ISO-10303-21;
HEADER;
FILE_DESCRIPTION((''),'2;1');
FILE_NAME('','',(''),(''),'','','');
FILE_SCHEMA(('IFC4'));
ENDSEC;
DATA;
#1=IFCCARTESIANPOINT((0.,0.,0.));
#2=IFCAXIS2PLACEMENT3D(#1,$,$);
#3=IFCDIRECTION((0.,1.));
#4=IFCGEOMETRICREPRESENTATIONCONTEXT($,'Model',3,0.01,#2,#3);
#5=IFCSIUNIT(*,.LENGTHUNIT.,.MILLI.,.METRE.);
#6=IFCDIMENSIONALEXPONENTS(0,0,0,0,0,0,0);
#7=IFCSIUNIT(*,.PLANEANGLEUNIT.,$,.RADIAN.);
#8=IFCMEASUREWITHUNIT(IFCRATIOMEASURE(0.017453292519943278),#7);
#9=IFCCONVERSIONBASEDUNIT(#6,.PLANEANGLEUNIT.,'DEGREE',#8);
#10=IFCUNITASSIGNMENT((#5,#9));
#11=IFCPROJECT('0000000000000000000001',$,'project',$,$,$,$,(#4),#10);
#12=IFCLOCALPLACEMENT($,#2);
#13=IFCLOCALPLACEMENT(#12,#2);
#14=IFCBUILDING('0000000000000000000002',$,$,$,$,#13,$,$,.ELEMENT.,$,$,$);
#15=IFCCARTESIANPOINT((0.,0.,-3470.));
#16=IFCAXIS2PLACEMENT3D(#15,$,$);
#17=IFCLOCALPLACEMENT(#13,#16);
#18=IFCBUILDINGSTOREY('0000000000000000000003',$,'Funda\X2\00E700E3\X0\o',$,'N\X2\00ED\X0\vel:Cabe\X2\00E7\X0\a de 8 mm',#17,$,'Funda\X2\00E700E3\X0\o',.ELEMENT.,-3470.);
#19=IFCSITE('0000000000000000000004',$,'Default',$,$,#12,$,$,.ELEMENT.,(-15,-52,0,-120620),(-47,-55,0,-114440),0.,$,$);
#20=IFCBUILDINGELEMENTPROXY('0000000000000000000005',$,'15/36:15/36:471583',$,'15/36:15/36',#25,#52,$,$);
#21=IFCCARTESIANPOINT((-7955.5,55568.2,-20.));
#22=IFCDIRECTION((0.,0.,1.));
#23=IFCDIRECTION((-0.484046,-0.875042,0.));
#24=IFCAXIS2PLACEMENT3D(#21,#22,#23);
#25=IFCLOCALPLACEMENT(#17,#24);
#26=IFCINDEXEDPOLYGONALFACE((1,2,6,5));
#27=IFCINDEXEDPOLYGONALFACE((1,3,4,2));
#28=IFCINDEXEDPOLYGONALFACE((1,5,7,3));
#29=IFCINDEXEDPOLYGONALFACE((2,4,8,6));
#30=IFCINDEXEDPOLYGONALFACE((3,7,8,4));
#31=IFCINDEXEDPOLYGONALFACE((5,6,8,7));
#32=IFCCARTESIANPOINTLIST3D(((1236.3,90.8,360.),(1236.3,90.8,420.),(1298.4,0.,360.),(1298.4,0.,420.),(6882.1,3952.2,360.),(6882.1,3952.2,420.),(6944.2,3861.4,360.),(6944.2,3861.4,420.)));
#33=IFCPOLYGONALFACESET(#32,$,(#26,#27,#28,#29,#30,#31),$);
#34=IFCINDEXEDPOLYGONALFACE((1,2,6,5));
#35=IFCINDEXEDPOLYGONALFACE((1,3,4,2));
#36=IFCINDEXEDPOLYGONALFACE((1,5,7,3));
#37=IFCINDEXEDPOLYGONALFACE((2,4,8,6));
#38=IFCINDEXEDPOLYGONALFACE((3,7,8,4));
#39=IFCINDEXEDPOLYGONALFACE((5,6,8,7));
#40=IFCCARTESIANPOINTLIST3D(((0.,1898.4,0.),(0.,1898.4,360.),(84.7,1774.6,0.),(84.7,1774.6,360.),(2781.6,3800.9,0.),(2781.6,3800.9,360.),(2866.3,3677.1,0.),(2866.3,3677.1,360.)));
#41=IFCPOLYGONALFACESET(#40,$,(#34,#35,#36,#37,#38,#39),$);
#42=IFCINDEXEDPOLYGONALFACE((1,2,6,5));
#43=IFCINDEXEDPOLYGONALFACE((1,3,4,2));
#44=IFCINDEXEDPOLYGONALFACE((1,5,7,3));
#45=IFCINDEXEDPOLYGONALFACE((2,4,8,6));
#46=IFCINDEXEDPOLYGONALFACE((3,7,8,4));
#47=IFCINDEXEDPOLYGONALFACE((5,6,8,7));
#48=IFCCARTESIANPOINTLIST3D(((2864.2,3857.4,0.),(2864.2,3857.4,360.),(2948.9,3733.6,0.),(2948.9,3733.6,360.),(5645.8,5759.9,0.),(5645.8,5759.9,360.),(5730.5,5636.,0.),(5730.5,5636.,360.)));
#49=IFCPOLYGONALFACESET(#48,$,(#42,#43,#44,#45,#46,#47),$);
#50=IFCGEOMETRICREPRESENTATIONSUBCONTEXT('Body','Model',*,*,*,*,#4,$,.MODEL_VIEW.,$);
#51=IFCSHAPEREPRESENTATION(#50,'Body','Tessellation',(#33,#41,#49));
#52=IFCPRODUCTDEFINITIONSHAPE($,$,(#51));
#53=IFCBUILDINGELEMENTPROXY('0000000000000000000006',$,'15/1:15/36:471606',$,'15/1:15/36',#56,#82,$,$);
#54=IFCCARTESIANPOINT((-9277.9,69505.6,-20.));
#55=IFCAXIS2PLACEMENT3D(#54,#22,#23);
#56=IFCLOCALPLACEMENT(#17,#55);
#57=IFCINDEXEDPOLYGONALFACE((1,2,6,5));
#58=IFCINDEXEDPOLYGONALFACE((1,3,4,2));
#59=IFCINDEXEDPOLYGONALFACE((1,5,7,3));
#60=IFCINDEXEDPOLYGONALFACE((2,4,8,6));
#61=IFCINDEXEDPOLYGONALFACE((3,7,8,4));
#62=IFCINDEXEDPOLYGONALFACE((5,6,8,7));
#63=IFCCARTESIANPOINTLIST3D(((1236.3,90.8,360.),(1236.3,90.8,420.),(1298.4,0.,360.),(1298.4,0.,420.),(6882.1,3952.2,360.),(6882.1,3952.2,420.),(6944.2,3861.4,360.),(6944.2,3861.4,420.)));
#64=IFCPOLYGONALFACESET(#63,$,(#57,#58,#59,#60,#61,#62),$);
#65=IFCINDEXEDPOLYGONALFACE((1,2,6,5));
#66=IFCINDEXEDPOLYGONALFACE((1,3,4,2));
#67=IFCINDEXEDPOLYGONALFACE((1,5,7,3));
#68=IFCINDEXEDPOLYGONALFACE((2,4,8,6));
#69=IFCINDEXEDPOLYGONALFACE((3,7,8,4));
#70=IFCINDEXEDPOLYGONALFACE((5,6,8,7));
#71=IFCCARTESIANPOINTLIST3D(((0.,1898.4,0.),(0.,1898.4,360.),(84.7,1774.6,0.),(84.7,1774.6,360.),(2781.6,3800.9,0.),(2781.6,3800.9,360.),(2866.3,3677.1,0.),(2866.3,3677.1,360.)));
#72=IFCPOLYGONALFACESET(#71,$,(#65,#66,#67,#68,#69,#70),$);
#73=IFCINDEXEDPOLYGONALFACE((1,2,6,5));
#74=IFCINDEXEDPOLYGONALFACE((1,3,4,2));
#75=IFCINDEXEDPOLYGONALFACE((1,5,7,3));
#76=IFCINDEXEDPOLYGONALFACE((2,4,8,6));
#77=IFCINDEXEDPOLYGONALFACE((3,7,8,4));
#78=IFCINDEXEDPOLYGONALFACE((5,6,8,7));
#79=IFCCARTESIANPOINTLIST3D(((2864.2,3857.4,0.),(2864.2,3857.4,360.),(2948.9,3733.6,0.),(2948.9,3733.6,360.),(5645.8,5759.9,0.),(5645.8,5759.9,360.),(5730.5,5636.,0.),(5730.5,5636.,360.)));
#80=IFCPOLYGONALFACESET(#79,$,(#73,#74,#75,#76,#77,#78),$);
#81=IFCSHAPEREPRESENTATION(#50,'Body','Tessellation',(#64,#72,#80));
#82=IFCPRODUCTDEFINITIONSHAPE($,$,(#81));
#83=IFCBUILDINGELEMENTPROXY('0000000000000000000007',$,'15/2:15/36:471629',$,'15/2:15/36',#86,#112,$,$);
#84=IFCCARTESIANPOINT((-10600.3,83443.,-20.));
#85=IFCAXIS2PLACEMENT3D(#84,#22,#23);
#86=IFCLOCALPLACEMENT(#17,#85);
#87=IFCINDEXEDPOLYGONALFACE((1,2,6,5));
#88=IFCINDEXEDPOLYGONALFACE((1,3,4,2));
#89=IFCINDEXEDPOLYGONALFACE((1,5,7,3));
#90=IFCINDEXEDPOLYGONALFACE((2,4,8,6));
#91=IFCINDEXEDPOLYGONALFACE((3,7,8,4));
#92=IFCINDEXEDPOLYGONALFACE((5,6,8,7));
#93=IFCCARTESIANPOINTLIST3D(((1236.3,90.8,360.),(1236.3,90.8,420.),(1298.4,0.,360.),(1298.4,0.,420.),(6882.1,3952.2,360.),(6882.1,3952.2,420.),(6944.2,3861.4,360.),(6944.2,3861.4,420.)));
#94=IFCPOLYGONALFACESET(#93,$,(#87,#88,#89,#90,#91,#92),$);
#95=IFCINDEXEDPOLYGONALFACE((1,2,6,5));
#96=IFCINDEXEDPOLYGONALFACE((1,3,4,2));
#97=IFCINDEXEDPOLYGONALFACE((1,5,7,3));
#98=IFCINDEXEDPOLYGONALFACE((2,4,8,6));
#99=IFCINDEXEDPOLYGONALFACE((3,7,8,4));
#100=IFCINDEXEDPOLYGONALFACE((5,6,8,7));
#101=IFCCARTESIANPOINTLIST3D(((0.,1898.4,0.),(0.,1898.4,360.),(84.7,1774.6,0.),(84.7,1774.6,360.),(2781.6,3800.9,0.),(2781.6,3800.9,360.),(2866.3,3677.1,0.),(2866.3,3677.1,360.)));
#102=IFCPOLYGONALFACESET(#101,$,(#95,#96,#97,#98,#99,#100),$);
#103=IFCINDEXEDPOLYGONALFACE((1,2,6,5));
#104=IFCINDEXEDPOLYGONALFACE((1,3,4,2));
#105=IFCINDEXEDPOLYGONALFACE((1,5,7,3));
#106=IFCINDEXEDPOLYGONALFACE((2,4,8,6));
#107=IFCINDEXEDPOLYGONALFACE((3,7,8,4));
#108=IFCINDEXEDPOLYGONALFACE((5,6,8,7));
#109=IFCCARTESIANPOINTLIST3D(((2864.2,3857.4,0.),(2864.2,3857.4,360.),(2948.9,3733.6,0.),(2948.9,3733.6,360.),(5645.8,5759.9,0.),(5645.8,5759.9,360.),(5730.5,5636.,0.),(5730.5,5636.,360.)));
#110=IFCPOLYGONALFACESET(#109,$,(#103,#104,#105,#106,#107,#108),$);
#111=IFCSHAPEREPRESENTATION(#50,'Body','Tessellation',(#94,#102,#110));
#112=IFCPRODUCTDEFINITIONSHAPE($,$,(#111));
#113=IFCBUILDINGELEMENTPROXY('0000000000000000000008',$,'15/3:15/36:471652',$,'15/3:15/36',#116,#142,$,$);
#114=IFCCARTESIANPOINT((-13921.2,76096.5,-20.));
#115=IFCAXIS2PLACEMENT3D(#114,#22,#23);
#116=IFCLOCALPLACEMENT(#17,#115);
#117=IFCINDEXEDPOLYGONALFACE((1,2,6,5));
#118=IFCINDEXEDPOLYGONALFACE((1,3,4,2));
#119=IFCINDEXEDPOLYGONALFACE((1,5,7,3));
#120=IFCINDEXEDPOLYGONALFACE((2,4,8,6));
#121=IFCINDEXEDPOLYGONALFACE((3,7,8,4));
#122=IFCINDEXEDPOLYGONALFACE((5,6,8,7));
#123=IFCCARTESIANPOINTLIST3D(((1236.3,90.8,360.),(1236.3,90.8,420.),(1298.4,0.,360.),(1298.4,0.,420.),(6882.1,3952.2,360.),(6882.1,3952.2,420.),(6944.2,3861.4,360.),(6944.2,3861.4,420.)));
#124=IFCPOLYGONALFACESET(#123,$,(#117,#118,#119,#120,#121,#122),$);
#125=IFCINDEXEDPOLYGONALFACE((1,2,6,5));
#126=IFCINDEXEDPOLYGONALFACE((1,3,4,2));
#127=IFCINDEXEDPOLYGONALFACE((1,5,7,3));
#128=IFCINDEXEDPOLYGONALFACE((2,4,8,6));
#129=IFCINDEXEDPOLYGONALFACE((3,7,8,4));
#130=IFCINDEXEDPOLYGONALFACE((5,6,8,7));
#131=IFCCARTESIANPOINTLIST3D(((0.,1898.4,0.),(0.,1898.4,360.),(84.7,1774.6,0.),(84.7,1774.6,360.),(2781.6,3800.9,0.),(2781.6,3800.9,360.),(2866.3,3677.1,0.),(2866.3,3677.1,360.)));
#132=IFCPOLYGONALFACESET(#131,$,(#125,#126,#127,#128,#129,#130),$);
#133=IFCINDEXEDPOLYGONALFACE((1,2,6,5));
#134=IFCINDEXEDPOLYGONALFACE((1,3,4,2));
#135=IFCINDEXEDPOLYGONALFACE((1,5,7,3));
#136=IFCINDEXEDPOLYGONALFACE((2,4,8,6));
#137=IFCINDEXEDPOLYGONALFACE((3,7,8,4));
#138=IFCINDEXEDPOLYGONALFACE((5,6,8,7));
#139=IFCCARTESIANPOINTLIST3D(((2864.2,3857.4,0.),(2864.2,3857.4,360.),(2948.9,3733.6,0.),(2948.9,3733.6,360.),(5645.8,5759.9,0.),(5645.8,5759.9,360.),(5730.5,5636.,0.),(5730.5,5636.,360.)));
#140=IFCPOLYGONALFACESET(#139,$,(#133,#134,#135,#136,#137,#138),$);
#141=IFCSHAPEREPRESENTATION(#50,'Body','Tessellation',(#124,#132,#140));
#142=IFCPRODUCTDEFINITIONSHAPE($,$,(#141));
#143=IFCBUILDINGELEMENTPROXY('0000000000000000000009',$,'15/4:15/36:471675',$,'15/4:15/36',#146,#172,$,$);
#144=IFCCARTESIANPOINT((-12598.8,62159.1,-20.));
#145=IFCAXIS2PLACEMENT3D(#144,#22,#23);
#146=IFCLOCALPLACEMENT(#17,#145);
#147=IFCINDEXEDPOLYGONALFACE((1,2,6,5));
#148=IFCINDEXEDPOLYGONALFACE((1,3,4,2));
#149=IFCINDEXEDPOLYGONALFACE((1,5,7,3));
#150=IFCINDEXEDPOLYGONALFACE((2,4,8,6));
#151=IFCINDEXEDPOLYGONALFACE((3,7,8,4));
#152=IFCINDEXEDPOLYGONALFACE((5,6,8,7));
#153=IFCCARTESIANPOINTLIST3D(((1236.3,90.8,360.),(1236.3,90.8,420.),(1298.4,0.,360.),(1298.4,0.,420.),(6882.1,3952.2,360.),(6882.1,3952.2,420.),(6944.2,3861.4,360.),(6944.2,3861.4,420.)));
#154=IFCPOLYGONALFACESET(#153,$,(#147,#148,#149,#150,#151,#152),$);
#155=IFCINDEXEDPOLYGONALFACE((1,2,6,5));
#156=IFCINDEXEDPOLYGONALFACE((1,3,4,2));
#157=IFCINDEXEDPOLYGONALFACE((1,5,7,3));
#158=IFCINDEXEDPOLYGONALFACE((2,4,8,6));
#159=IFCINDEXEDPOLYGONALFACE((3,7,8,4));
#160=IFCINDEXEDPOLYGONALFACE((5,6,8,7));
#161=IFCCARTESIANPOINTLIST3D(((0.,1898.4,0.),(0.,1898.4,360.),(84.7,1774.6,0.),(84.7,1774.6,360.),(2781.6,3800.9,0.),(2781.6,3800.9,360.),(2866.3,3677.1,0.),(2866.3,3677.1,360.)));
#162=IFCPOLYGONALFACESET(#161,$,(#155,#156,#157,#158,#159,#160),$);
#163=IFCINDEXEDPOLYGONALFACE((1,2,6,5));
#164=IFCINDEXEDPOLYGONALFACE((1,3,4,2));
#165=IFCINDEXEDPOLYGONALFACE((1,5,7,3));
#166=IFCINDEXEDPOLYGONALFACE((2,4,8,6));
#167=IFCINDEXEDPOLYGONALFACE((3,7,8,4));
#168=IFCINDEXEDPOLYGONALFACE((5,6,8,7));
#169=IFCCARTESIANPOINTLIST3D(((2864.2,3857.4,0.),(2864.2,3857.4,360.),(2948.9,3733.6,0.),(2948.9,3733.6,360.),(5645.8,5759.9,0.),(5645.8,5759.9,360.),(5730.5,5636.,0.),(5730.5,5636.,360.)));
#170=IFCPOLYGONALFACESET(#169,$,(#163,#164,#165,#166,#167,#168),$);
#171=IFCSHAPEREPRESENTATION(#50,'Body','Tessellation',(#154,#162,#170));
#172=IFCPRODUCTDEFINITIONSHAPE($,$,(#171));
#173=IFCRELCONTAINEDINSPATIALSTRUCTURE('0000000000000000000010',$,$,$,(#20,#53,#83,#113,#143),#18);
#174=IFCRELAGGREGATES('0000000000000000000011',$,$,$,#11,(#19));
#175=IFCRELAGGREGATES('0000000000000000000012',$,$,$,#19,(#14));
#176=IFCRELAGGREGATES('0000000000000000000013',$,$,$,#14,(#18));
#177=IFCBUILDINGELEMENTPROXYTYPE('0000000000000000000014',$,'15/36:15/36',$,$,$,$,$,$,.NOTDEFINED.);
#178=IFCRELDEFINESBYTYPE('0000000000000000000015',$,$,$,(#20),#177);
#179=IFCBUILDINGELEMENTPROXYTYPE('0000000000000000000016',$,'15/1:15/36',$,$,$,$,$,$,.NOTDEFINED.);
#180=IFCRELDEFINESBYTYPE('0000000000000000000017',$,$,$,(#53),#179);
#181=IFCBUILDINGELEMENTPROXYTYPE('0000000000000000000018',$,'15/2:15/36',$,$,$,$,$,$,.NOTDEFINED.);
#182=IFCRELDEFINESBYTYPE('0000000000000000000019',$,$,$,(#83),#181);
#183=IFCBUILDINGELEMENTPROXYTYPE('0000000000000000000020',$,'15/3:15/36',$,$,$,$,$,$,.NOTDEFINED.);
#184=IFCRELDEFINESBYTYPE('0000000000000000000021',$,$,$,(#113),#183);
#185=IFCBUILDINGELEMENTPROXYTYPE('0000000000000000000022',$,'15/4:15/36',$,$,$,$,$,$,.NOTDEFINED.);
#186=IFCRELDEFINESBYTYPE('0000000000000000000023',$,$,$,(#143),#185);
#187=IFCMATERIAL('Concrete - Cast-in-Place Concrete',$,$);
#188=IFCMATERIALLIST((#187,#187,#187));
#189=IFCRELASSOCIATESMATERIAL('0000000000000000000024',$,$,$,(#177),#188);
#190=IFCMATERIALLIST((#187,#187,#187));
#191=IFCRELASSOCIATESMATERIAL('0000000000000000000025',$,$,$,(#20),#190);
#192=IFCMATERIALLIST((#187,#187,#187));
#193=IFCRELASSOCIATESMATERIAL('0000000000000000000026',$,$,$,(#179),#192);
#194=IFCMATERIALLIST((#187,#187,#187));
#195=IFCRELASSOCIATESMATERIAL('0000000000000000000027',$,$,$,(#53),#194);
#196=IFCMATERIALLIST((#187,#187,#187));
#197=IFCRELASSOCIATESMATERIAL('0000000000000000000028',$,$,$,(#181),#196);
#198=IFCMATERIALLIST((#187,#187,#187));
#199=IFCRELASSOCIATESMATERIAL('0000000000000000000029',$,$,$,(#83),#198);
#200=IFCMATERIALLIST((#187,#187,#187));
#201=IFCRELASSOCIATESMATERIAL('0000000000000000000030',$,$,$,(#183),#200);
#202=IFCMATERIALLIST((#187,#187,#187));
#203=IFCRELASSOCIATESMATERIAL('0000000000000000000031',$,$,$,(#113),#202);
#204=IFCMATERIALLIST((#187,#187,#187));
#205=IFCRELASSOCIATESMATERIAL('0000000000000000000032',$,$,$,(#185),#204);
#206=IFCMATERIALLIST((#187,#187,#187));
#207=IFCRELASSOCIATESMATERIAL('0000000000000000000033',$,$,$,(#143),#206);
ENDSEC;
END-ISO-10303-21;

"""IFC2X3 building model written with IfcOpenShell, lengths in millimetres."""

from ifc_helpers import new_model, entity, si_unit, converted_unit, direction, frame, frame_2d, origin, place, context, subcontext, project, spatial, rectangle, extrude, source, transform, mapped, material, material_list, type_object, type_shapes, element, save


model = new_model("IFC2X3")

# Units and contexts
model_context = context("Model", 3, precision=0.01, world=origin(), true_north=direction((0.0, 1.0)))
body_context = subcontext(model_context, "Body", "Model", "MODEL_VIEW")
ifc_project = project(units=[si_unit("LENGTHUNIT", "METRE", prefix="MILLI"), converted_unit("PLANEANGLEUNIT", "DEGREE", entity("IfcRatioMeasure", 0.017453292519943278), si_unit("PLANEANGLEUNIT", "RADIAN"), dimensions=[0, 0, 0, 0, 0, 0, 0])], contexts=[model_context])

# Site, building, storey
site_placement = place(None, origin())
site = spatial("IfcSite", under=ifc_project, at=site_placement, Name="Default", CompositionType="ELEMENT", RefLatitude=(-15, -52, 0, -120620), RefLongitude=(-47, -55, 0, -114440), RefElevation=0.0)
building_placement = place(site_placement, origin())
building = spatial("IfcBuilding", under=site, at=building_placement, CompositionType="ELEMENT")
storey_placement = place(building_placement, frame((0.0, 0.0, -3470.0)))
storey = spatial("IfcBuildingStorey", under=building, at=storey_placement, Name="Fundação", ObjectType="Nível:Cabeça de 8 mm", LongName="Fundação", CompositionType="ELEMENT", Elevation=-3470.0)

# Building element proxies
ifc_material_1 = material(Name="Concrete - Cast-in-Place Concrete")
ifc_material_list_1 = material_list([ifc_material_1, ifc_material_1, ifc_material_1])
ifc_material_list_2 = material_list([ifc_material_1, ifc_material_1, ifc_material_1])
building_element_proxy_type_1 = type_object("IfcBuildingElementProxyType", Name="15/36:15/36", PredefinedType="NOTDEFINED", material=ifc_material_list_2)
shared_shape_1 = source(origin(), body_context, "Body", "SweptSolid", [
    extrude(rectangle(XDim=110.0, YDim=6840.0, at=frame_2d((0.0, 0.0), x_axis=(1.0, 0.0))), frame((4090.3, 1976.1, 360.0), z_axis=(0.0, 0.0, 1.0), x_axis=(-0.564535, 0.825409, 0.0)), (0.0, 0.0, 1.0), 60.0),
    extrude(rectangle(XDim=3370.0, YDim=150.0, at=frame_2d((0.0, 0.0), x_axis=(1.0, 0.0))), frame((1433.2, 2787.8, 0.0), z_axis=(0.0, 0.0, 1.0), x_axis=(0.825409, 0.564535, 0.0)), (0.0, 0.0, 1.0), 360.0),
    extrude(rectangle(XDim=3370.0, YDim=150.0, at=frame_2d((0.0, 0.0), x_axis=(1.0, 0.0))), frame((4297.3, 4746.7, 0.0), z_axis=(0.0, 0.0, 1.0), x_axis=(0.825409, 0.564535, 0.0)), (0.0, 0.0, 1.0), 360.0),
])
type_shapes(building_element_proxy_type_1, [shared_shape_1])
proxy_1_placement = place(storey_placement, frame((-7955.5, 55568.2, -20.0), z_axis=(0.0, 0.0, 1.0), x_axis=(-0.484046, -0.875042, 0.0)))
element("IfcBuildingElementProxy", 1, at=proxy_1_placement, inside=storey, type_object=building_element_proxy_type_1, material=ifc_material_list_1, Name="15/36:15/36:471583", ObjectType="15/36:15/36", context=body_context, shape_type="MappedRepresentation", body=[
    mapped(shared_shape_1, transform((0.0, 0.0, 0.0), scale=1.0)),
])
ifc_material_list_3 = material_list([ifc_material_1, ifc_material_1, ifc_material_1])
ifc_material_list_4 = material_list([ifc_material_1, ifc_material_1, ifc_material_1])
building_element_proxy_type_2 = type_object("IfcBuildingElementProxyType", Name="15/1:15/36", PredefinedType="NOTDEFINED", material=ifc_material_list_4)
shared_shape_2 = source(origin(), body_context, "Body", "SweptSolid", [
    extrude(rectangle(XDim=110.0, YDim=6840.0, at=frame_2d((0.0, 0.0), x_axis=(1.0, 0.0))), frame((4090.3, 1976.1, 360.0), z_axis=(0.0, 0.0, 1.0), x_axis=(-0.564535, 0.825409, 0.0)), (0.0, 0.0, 1.0), 60.0),
    extrude(rectangle(XDim=3370.0, YDim=150.0, at=frame_2d((0.0, 0.0), x_axis=(1.0, 0.0))), frame((1433.2, 2787.8, 0.0), z_axis=(0.0, 0.0, 1.0), x_axis=(0.825409, 0.564535, 0.0)), (0.0, 0.0, 1.0), 360.0),
    extrude(rectangle(XDim=3370.0, YDim=150.0, at=frame_2d((0.0, 0.0), x_axis=(1.0, 0.0))), frame((4297.3, 4746.7, 0.0), z_axis=(0.0, 0.0, 1.0), x_axis=(0.825409, 0.564535, 0.0)), (0.0, 0.0, 1.0), 360.0),
])
type_shapes(building_element_proxy_type_2, [shared_shape_2])
proxy_2_placement = place(storey_placement, frame((-9277.9, 69505.6, -20.0), z_axis=(0.0, 0.0, 1.0), x_axis=(-0.484046, -0.875042, 0.0)))
element("IfcBuildingElementProxy", 2, at=proxy_2_placement, inside=storey, type_object=building_element_proxy_type_2, material=ifc_material_list_3, Name="15/1:15/36:471606", ObjectType="15/1:15/36", context=body_context, shape_type="MappedRepresentation", body=[
    mapped(shared_shape_2, transform((0.0, 0.0, 0.0), scale=1.0)),
])
ifc_material_list_5 = material_list([ifc_material_1, ifc_material_1, ifc_material_1])
ifc_material_list_6 = material_list([ifc_material_1, ifc_material_1, ifc_material_1])
building_element_proxy_type_3 = type_object("IfcBuildingElementProxyType", Name="15/2:15/36", PredefinedType="NOTDEFINED", material=ifc_material_list_6)
shared_shape_3 = source(origin(), body_context, "Body", "SweptSolid", [
    extrude(rectangle(XDim=110.0, YDim=6840.0, at=frame_2d((0.0, 0.0), x_axis=(1.0, 0.0))), frame((4090.3, 1976.1, 360.0), z_axis=(0.0, 0.0, 1.0), x_axis=(-0.564535, 0.825409, 0.0)), (0.0, 0.0, 1.0), 60.0),
    extrude(rectangle(XDim=3370.0, YDim=150.0, at=frame_2d((0.0, 0.0), x_axis=(1.0, 0.0))), frame((1433.2, 2787.8, 0.0), z_axis=(0.0, 0.0, 1.0), x_axis=(0.825409, 0.564535, 0.0)), (0.0, 0.0, 1.0), 360.0),
    extrude(rectangle(XDim=3370.0, YDim=150.0, at=frame_2d((0.0, 0.0), x_axis=(1.0, 0.0))), frame((4297.3, 4746.7, 0.0), z_axis=(0.0, 0.0, 1.0), x_axis=(0.825409, 0.564535, 0.0)), (0.0, 0.0, 1.0), 360.0),
])
type_shapes(building_element_proxy_type_3, [shared_shape_3])
proxy_3_placement = place(storey_placement, frame((-10600.3, 83443.0, -20.0), z_axis=(0.0, 0.0, 1.0), x_axis=(-0.484046, -0.875042, 0.0)))
element("IfcBuildingElementProxy", 3, at=proxy_3_placement, inside=storey, type_object=building_element_proxy_type_3, material=ifc_material_list_5, Name="15/2:15/36:471629", ObjectType="15/2:15/36", context=body_context, shape_type="MappedRepresentation", body=[
    mapped(shared_shape_3, transform((0.0, 0.0, 0.0), scale=1.0)),
])
ifc_material_list_7 = material_list([ifc_material_1, ifc_material_1, ifc_material_1])
ifc_material_list_8 = material_list([ifc_material_1, ifc_material_1, ifc_material_1])
building_element_proxy_type_4 = type_object("IfcBuildingElementProxyType", Name="15/3:15/36", PredefinedType="NOTDEFINED", material=ifc_material_list_8)
shared_shape_4 = source(origin(), body_context, "Body", "SweptSolid", [
    extrude(rectangle(XDim=110.0, YDim=6840.0, at=frame_2d((0.0, 0.0), x_axis=(1.0, 0.0))), frame((4090.3, 1976.1, 360.0), z_axis=(0.0, 0.0, 1.0), x_axis=(-0.564535, 0.825409, 0.0)), (0.0, 0.0, 1.0), 60.0),
    extrude(rectangle(XDim=3370.0, YDim=150.0, at=frame_2d((0.0, 0.0), x_axis=(1.0, 0.0))), frame((1433.2, 2787.8, 0.0), z_axis=(0.0, 0.0, 1.0), x_axis=(0.825409, 0.564535, 0.0)), (0.0, 0.0, 1.0), 360.0),
    extrude(rectangle(XDim=3370.0, YDim=150.0, at=frame_2d((0.0, 0.0), x_axis=(1.0, 0.0))), frame((4297.3, 4746.7, 0.0), z_axis=(0.0, 0.0, 1.0), x_axis=(0.825409, 0.564535, 0.0)), (0.0, 0.0, 1.0), 360.0),
])
type_shapes(building_element_proxy_type_4, [shared_shape_4])
proxy_4_placement = place(storey_placement, frame((-13921.2, 76096.5, -20.0), z_axis=(0.0, 0.0, 1.0), x_axis=(-0.484046, -0.875042, 0.0)))
element("IfcBuildingElementProxy", 4, at=proxy_4_placement, inside=storey, type_object=building_element_proxy_type_4, material=ifc_material_list_7, Name="15/3:15/36:471652", ObjectType="15/3:15/36", context=body_context, shape_type="MappedRepresentation", body=[
    mapped(shared_shape_4, transform((0.0, 0.0, 0.0), scale=1.0)),
])
ifc_material_list_9 = material_list([ifc_material_1, ifc_material_1, ifc_material_1])
ifc_material_list_10 = material_list([ifc_material_1, ifc_material_1, ifc_material_1])
building_element_proxy_type_5 = type_object("IfcBuildingElementProxyType", Name="15/4:15/36", PredefinedType="NOTDEFINED", material=ifc_material_list_10)
shared_shape_5 = source(origin(), body_context, "Body", "SweptSolid", [
    extrude(rectangle(XDim=110.0, YDim=6840.0, at=frame_2d((0.0, 0.0), x_axis=(1.0, 0.0))), frame((4090.3, 1976.1, 360.0), z_axis=(0.0, 0.0, 1.0), x_axis=(-0.564535, 0.825409, 0.0)), (0.0, 0.0, 1.0), 60.0),
    extrude(rectangle(XDim=3370.0, YDim=150.0, at=frame_2d((0.0, 0.0), x_axis=(1.0, 0.0))), frame((1433.2, 2787.8, 0.0), z_axis=(0.0, 0.0, 1.0), x_axis=(0.825409, 0.564535, 0.0)), (0.0, 0.0, 1.0), 360.0),
    extrude(rectangle(XDim=3370.0, YDim=150.0, at=frame_2d((0.0, 0.0), x_axis=(1.0, 0.0))), frame((4297.3, 4746.7, 0.0), z_axis=(0.0, 0.0, 1.0), x_axis=(0.825409, 0.564535, 0.0)), (0.0, 0.0, 1.0), 360.0),
])
type_shapes(building_element_proxy_type_5, [shared_shape_5])
proxy_5_placement = place(storey_placement, frame((-12598.8, 62159.1, -20.0), z_axis=(0.0, 0.0, 1.0), x_axis=(-0.484046, -0.875042, 0.0)))
element("IfcBuildingElementProxy", 5, at=proxy_5_placement, inside=storey, type_object=building_element_proxy_type_5, material=ifc_material_list_9, Name="15/4:15/36:471675", ObjectType="15/4:15/36", context=body_context, shape_type="MappedRepresentation", body=[
    mapped(shared_shape_5, transform((0.0, 0.0, 0.0), scale=1.0)),
])

save(model, "model.ifc")
